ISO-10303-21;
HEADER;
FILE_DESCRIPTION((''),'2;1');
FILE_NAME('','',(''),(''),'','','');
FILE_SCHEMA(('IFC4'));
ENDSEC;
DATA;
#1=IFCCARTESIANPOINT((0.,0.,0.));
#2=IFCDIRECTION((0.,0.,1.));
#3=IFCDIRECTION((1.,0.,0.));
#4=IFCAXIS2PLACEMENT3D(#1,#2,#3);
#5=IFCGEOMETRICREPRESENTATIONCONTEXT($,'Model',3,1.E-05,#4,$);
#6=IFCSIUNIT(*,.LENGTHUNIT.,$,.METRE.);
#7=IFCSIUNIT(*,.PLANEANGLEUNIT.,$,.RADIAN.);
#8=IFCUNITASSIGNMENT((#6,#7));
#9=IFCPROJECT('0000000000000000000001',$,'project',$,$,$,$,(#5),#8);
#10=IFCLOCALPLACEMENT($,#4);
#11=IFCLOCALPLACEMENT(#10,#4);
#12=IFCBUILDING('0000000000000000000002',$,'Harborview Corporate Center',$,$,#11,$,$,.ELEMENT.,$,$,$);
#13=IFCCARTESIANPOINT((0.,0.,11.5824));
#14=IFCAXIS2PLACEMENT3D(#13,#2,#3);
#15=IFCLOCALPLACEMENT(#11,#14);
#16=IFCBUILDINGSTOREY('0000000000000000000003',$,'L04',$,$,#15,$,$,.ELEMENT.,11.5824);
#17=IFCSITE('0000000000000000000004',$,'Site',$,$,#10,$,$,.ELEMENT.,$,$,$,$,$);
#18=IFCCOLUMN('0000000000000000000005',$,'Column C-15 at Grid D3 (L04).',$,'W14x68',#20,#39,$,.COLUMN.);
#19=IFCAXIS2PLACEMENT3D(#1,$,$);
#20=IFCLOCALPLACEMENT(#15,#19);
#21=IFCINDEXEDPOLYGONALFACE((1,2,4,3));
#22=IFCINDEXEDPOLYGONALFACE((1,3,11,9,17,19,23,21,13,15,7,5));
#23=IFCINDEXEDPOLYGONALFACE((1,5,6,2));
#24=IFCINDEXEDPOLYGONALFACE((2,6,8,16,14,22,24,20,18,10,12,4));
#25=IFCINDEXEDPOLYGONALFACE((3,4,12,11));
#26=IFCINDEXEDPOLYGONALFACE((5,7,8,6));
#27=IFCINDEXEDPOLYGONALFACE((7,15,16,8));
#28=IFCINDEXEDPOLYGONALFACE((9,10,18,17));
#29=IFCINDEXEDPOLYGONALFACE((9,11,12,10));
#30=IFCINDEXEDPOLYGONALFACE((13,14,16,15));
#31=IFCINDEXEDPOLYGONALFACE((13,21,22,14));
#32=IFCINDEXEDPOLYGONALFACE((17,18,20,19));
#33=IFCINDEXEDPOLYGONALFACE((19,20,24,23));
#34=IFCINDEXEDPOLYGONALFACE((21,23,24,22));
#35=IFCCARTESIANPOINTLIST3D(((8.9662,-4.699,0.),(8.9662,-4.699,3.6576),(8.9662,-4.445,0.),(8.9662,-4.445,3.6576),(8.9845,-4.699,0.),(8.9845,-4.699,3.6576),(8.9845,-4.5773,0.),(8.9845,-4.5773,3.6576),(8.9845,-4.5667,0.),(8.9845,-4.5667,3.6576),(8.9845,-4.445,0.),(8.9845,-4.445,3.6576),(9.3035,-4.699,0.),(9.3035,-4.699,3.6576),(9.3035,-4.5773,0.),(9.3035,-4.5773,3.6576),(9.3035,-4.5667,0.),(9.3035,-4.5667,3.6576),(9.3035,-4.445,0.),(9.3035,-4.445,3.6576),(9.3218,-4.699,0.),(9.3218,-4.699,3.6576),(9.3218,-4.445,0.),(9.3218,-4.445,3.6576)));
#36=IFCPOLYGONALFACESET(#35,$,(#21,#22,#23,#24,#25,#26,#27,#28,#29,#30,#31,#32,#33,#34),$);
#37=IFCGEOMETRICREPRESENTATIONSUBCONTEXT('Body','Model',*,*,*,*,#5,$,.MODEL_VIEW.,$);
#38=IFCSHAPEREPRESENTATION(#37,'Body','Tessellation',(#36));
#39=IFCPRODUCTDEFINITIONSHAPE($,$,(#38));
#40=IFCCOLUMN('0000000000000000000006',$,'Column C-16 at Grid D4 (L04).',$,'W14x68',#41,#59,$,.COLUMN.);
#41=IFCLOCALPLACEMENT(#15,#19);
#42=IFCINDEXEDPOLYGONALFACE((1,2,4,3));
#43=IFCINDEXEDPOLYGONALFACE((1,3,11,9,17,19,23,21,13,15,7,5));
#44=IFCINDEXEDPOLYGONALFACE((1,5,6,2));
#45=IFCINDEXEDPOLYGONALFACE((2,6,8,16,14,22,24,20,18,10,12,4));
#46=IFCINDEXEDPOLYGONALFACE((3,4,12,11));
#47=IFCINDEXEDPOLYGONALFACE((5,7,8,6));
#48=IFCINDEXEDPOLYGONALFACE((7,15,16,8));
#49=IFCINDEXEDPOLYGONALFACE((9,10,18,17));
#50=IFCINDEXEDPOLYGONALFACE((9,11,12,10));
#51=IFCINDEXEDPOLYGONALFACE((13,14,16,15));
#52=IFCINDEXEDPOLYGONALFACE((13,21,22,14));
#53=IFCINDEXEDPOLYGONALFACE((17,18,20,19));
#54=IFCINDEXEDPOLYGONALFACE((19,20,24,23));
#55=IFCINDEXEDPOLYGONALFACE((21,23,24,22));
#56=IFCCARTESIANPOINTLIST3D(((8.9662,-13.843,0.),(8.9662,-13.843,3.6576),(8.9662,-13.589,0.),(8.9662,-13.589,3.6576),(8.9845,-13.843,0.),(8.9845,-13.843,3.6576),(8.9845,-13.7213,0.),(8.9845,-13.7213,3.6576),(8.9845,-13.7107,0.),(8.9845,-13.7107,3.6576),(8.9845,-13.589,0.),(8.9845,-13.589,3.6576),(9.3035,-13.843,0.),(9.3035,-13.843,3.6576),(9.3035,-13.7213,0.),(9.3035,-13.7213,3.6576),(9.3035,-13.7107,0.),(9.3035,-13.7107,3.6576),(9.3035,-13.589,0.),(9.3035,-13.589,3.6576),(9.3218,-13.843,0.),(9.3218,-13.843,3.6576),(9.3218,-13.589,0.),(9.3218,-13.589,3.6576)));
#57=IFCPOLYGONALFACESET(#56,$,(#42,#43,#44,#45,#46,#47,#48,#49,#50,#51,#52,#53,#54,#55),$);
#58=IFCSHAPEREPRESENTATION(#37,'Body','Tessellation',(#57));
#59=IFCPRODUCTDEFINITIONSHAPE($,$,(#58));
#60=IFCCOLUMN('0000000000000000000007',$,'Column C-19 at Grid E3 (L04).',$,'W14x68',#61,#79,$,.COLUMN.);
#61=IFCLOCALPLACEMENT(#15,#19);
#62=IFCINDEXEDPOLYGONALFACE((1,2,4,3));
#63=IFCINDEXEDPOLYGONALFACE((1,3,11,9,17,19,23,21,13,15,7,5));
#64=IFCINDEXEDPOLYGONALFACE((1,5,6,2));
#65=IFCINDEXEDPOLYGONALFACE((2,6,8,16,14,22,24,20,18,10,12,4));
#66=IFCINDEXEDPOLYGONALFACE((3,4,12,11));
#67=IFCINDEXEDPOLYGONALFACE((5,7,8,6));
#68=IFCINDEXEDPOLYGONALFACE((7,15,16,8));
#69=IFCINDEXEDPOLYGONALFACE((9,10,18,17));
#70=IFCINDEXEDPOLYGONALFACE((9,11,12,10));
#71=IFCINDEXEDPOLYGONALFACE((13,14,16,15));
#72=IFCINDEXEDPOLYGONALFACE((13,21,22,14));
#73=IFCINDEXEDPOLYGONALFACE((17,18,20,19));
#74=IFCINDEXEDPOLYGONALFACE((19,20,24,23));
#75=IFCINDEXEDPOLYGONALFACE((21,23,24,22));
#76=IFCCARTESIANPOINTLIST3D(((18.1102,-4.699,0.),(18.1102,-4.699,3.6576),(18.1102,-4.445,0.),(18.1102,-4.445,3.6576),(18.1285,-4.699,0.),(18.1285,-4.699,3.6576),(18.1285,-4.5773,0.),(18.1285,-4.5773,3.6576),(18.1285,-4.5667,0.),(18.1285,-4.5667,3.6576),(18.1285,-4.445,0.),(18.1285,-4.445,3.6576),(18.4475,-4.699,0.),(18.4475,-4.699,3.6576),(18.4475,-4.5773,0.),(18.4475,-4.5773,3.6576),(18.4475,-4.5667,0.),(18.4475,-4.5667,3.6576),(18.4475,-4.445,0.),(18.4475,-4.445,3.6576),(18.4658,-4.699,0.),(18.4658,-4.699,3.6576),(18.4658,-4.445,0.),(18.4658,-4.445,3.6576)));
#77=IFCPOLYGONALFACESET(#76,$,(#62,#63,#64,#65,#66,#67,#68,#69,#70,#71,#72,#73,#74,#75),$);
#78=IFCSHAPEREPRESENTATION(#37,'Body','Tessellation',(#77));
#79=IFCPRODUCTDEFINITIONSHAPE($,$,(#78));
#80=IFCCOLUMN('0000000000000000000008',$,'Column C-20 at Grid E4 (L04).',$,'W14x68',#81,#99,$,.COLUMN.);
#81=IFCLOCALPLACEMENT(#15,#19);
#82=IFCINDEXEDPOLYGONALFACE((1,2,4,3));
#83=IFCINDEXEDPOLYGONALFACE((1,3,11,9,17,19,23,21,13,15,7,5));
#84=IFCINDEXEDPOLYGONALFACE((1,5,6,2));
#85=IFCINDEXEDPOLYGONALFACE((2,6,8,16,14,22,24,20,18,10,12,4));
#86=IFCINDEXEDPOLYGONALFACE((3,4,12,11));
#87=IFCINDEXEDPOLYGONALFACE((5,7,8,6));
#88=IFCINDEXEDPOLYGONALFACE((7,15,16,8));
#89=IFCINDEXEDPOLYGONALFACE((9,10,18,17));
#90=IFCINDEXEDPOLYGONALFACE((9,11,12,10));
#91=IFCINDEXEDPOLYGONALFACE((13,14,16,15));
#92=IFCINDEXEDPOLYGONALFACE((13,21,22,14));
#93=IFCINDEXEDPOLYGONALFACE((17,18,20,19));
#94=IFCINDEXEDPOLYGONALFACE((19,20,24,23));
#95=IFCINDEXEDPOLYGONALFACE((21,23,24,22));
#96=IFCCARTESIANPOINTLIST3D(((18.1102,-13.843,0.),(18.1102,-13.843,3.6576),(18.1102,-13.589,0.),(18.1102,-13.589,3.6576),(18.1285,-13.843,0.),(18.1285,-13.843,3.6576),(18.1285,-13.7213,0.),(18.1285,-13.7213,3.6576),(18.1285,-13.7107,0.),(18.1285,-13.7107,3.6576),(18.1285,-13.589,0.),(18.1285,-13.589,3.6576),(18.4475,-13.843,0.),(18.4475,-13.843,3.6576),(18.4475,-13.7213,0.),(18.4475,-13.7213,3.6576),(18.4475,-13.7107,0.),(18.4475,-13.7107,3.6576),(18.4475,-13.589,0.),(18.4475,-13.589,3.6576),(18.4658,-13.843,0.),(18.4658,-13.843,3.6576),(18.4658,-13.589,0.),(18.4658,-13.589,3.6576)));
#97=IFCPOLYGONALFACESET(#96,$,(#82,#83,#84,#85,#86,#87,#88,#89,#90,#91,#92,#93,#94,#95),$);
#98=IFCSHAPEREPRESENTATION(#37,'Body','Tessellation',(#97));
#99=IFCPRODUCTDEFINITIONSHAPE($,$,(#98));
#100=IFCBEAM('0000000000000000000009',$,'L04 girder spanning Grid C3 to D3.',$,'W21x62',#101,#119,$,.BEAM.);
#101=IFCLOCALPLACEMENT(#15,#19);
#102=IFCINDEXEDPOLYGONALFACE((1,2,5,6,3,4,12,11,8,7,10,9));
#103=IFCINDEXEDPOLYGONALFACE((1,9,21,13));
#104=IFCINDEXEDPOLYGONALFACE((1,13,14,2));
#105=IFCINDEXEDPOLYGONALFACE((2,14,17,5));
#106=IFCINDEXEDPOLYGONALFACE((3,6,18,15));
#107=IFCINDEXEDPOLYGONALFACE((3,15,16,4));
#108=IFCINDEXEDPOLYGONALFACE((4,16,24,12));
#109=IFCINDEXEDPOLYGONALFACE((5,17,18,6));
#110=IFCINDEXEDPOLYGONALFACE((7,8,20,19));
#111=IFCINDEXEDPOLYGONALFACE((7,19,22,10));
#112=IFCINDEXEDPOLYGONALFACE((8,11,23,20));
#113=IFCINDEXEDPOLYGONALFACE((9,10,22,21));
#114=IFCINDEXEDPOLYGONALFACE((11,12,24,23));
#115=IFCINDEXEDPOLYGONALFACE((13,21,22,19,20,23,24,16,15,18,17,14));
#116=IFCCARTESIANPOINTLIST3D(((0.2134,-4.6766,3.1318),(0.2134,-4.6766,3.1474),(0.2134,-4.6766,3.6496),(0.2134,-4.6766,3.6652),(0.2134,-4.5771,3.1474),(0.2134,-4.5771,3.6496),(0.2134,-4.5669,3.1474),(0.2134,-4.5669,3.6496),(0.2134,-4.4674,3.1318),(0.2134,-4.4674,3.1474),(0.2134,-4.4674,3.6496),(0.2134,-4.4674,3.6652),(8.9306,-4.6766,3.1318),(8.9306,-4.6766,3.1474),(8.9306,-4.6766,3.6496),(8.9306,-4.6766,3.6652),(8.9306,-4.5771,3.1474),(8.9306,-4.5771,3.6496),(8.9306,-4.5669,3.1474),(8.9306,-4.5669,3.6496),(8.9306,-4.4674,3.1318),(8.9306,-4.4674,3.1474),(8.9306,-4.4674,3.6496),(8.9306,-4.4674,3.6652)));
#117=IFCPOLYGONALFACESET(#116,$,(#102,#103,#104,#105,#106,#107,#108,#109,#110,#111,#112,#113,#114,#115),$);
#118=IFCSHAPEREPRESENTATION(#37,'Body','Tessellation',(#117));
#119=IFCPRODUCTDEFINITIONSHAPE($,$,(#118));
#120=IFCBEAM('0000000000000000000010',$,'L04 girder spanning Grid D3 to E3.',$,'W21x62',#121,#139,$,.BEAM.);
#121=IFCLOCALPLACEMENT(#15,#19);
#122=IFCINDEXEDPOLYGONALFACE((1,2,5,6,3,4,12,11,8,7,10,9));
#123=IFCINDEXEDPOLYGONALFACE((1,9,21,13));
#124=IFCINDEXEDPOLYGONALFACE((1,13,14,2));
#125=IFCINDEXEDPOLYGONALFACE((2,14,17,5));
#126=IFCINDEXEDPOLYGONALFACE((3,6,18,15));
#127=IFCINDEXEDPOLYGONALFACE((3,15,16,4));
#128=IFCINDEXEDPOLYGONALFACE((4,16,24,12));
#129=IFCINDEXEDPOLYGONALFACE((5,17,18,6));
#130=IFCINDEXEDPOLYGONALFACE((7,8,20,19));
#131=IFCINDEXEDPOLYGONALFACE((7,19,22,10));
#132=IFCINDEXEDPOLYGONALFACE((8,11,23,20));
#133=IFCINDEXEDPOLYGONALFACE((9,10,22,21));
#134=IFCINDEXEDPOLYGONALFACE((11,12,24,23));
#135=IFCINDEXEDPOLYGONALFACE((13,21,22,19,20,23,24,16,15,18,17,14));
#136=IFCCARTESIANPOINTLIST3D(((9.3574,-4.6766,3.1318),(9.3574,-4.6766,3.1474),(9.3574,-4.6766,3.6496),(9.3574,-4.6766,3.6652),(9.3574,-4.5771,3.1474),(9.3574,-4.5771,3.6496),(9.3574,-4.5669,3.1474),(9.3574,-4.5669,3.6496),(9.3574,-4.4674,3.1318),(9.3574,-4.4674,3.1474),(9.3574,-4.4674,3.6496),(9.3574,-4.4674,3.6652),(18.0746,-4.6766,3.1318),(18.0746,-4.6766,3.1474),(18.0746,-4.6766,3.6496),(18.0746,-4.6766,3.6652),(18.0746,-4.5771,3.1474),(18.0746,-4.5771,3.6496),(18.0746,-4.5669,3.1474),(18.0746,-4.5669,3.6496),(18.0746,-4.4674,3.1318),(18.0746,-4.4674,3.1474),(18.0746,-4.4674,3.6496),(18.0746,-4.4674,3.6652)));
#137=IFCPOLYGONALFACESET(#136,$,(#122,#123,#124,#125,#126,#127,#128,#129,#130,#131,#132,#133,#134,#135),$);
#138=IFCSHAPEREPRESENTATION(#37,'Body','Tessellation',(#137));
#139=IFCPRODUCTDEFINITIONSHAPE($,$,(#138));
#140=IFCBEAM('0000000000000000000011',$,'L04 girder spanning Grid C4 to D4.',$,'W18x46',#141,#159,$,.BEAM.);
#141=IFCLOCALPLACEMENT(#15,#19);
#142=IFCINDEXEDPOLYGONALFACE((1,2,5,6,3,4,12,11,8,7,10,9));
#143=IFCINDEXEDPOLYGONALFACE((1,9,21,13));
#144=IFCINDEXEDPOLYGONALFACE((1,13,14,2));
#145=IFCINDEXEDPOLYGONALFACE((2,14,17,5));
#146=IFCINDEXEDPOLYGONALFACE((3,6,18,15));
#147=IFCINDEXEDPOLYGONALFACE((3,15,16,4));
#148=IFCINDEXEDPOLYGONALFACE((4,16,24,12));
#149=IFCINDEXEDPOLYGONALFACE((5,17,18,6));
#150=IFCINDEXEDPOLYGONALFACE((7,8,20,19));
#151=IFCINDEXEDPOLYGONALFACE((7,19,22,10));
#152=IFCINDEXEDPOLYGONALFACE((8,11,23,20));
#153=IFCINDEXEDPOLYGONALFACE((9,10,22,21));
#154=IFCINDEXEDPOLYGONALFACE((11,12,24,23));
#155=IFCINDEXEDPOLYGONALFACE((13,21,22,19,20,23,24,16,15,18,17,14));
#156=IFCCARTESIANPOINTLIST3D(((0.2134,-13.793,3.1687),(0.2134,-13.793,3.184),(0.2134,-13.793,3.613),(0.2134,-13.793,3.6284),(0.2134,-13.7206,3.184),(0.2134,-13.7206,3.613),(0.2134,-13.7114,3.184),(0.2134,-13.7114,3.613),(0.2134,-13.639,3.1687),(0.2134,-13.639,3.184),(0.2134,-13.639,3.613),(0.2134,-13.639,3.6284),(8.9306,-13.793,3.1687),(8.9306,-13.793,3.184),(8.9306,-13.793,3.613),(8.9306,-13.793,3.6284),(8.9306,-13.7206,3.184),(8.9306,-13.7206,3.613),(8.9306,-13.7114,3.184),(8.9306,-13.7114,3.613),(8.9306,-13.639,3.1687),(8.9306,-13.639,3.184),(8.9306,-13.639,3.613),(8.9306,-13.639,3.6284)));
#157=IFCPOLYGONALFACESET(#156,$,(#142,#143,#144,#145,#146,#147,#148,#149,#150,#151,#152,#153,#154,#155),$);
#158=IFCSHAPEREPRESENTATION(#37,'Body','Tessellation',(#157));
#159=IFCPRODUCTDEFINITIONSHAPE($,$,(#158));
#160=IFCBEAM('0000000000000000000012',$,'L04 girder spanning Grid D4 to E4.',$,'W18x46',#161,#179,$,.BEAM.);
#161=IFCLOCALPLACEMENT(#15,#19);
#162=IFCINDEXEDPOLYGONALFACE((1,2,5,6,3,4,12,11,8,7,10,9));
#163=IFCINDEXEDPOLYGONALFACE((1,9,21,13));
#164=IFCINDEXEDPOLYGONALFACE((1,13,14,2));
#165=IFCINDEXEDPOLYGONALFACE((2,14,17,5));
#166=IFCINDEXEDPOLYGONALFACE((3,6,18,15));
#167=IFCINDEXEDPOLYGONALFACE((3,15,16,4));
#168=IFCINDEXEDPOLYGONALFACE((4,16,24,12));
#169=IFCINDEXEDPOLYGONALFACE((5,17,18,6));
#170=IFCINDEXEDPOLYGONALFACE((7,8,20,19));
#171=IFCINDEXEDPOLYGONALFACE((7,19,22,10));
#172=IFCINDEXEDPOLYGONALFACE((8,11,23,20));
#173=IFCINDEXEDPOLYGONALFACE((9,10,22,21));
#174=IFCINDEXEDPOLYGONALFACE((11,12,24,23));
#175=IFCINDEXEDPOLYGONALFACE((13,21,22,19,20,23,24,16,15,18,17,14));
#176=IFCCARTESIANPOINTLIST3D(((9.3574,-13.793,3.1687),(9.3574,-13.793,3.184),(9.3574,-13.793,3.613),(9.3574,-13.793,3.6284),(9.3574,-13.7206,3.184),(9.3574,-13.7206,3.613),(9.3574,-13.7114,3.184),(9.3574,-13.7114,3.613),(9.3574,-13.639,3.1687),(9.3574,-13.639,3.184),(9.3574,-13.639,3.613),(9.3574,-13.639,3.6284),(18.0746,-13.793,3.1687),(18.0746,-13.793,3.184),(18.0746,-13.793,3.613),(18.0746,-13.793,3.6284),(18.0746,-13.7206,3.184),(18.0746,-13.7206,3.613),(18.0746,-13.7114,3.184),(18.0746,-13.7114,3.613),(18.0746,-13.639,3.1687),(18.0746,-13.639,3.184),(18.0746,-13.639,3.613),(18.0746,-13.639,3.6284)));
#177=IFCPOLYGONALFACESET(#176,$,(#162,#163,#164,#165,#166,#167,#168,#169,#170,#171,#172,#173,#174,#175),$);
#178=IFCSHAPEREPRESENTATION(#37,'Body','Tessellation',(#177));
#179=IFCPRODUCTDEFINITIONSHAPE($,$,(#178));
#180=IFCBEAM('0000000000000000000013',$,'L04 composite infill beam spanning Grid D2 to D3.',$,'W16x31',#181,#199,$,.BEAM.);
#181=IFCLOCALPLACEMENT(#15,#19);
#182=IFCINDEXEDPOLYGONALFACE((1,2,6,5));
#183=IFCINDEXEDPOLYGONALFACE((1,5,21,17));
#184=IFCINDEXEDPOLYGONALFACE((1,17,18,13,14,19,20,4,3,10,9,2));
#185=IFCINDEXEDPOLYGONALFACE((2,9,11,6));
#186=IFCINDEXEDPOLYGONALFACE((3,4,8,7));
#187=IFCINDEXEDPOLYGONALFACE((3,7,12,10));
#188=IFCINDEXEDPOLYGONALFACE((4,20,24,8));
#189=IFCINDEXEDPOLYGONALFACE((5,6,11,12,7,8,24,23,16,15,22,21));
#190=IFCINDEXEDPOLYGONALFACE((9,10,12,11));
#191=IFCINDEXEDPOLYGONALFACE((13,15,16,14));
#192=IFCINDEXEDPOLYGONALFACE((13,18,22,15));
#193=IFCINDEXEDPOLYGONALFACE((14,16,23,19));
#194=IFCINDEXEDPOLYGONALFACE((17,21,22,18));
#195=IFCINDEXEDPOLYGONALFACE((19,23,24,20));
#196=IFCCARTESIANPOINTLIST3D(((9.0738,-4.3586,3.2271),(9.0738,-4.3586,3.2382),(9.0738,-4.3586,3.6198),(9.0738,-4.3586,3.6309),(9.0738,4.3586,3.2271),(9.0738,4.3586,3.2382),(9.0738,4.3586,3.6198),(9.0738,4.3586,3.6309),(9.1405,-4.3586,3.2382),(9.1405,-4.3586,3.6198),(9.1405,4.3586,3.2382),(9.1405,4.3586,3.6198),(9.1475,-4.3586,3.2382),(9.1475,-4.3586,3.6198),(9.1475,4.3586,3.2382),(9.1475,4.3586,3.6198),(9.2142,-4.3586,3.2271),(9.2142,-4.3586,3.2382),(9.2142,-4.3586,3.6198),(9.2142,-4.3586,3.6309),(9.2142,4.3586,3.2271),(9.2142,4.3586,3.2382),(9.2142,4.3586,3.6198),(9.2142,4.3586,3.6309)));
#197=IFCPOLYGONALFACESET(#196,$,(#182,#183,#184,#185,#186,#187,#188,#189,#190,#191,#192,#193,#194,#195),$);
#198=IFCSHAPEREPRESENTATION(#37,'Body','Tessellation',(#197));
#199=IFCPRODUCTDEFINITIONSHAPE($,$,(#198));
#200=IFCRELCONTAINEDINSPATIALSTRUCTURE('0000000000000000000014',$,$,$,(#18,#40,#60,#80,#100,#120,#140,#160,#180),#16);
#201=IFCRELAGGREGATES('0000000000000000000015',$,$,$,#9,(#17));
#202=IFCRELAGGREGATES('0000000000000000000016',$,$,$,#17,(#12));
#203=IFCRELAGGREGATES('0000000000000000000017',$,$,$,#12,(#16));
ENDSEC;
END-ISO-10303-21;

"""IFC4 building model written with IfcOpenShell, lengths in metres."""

from ifc_helpers import new_model, si_unit, frame, origin_with_axes, place, context, subcontext, project, spatial, i_section, extrude, element, save


model = new_model("IFC4")

# Units and contexts
model_context = context("Model", 3, precision=1e-05, world=origin_with_axes())
body_context = subcontext(model_context, "Body", "Model", "MODEL_VIEW")
ifc_project = project(units=[si_unit("LENGTHUNIT", "METRE"), si_unit("PLANEANGLEUNIT", "RADIAN")], contexts=[model_context])

# Site, building, storey
site_placement = place(None, origin_with_axes())
site = spatial("IfcSite", under=ifc_project, at=site_placement, Name="Site", CompositionType="ELEMENT")
building_placement = place(site_placement, origin_with_axes())
building = spatial("IfcBuilding", under=site, at=building_placement, Name="Harborview Corporate Center", CompositionType="ELEMENT")
storey_placement = place(building_placement, frame((0.0, 0.0, 11.5824), z_axis=(0.0, 0.0, 1.0), x_axis=(1.0, 0.0, 0.0)))
storey = spatial("IfcBuildingStorey", under=building, at=storey_placement, Name="L04", CompositionType="ELEMENT", Elevation=11.5824)

# Columns
for number, where, z_axis, x_axis, name in (
    (1, (9.144, -4.572, 0.0), (0.0, 0.0, 1.0), (0.0, 1.0, 0.0), "Column C-15 at Grid D3 (L04)."),
    (2, (9.144, -13.716, 0.0), (0.0, 0.0, 1.0), (0.0, 1.0, 0.0), "Column C-16 at Grid D4 (L04)."),
    (3, (18.288, -4.572, 0.0), (0.0, 0.0, 1.0), (0.0, 1.0, 0.0), "Column C-19 at Grid E3 (L04)."),
    (4, (18.288, -13.716, 0.0), (0.0, 0.0, 1.0), (0.0, 1.0, 0.0), "Column C-20 at Grid E4 (L04)."),
):
    element("IfcColumn", number, at=place(storey_placement, frame(where, z_axis=z_axis, x_axis=x_axis)), inside=storey, Name=name, ObjectType="W14x68", PredefinedType="COLUMN", context=body_context, shape_type="SweptSolid", body=[
        extrude(i_section(OverallWidth=0.254, OverallDepth=0.3556, WebThickness=0.0105, FlangeThickness=0.0183), origin_with_axes(), (0.0, 0.0, 1.0), 3.6576),
    ])

# Beams
beam_1_placement = place(storey_placement, frame((0.2134, -4.572, 3.3985), z_axis=(1.0, 0.0, 0.0), x_axis=(0.0, 1.0, 0.0)))
element("IfcBeam", 5, at=beam_1_placement, inside=storey, Name="L04 girder spanning Grid C3 to D3.", ObjectType="W21x62", PredefinedType="BEAM", context=body_context, shape_type="SweptSolid", body=[
    extrude(i_section(OverallWidth=0.2093, OverallDepth=0.5334, WebThickness=0.0102, FlangeThickness=0.0156), origin_with_axes(), (0.0, 0.0, 1.0), 8.7173),
])
beam_2_placement = place(storey_placement, frame((9.3574, -4.572, 3.3985), z_axis=(1.0, 0.0, 0.0), x_axis=(0.0, 1.0, 0.0)))
element("IfcBeam", 6, at=beam_2_placement, inside=storey, Name="L04 girder spanning Grid D3 to E3.", ObjectType="W21x62", PredefinedType="BEAM", context=body_context, shape_type="SweptSolid", body=[
    extrude(i_section(OverallWidth=0.2093, OverallDepth=0.5334, WebThickness=0.0102, FlangeThickness=0.0156), origin_with_axes(), (0.0, 0.0, 1.0), 8.7173),
])
beam_3_placement = place(storey_placement, frame((0.2134, -13.716, 3.3985), z_axis=(1.0, 0.0, 0.0), x_axis=(0.0, 1.0, 0.0)))
element("IfcBeam", 7, at=beam_3_placement, inside=storey, Name="L04 girder spanning Grid C4 to D4.", ObjectType="W18x46", PredefinedType="BEAM", context=body_context, shape_type="SweptSolid", body=[
    extrude(i_section(OverallWidth=0.1539, OverallDepth=0.4597, WebThickness=0.0091, FlangeThickness=0.0154), origin_with_axes(), (0.0, 0.0, 1.0), 8.7173),
])
beam_4_placement = place(storey_placement, frame((9.3574, -13.716, 3.3985), z_axis=(1.0, 0.0, 0.0), x_axis=(0.0, 1.0, 0.0)))
element("IfcBeam", 8, at=beam_4_placement, inside=storey, Name="L04 girder spanning Grid D4 to E4.", ObjectType="W18x46", PredefinedType="BEAM", context=body_context, shape_type="SweptSolid", body=[
    extrude(i_section(OverallWidth=0.1539, OverallDepth=0.4597, WebThickness=0.0091, FlangeThickness=0.0154), origin_with_axes(), (0.0, 0.0, 1.0), 8.7173),
])
beam_5_placement = place(storey_placement, frame((9.144, -4.3586, 3.429), z_axis=(0.0, 1.0, 0.0), x_axis=(-1.0, 0.0, 0.0)))
element("IfcBeam", 9, at=beam_5_placement, inside=storey, Name="L04 composite infill beam spanning Grid D2 to D3.", ObjectType="W16x31", PredefinedType="BEAM", context=body_context, shape_type="SweptSolid", body=[
    extrude(i_section(OverallWidth=0.1405, OverallDepth=0.4039, WebThickness=0.007, FlangeThickness=0.0112), origin_with_axes(), (0.0, 0.0, 1.0), 8.7173),
])

save(model, "model.ifc")
